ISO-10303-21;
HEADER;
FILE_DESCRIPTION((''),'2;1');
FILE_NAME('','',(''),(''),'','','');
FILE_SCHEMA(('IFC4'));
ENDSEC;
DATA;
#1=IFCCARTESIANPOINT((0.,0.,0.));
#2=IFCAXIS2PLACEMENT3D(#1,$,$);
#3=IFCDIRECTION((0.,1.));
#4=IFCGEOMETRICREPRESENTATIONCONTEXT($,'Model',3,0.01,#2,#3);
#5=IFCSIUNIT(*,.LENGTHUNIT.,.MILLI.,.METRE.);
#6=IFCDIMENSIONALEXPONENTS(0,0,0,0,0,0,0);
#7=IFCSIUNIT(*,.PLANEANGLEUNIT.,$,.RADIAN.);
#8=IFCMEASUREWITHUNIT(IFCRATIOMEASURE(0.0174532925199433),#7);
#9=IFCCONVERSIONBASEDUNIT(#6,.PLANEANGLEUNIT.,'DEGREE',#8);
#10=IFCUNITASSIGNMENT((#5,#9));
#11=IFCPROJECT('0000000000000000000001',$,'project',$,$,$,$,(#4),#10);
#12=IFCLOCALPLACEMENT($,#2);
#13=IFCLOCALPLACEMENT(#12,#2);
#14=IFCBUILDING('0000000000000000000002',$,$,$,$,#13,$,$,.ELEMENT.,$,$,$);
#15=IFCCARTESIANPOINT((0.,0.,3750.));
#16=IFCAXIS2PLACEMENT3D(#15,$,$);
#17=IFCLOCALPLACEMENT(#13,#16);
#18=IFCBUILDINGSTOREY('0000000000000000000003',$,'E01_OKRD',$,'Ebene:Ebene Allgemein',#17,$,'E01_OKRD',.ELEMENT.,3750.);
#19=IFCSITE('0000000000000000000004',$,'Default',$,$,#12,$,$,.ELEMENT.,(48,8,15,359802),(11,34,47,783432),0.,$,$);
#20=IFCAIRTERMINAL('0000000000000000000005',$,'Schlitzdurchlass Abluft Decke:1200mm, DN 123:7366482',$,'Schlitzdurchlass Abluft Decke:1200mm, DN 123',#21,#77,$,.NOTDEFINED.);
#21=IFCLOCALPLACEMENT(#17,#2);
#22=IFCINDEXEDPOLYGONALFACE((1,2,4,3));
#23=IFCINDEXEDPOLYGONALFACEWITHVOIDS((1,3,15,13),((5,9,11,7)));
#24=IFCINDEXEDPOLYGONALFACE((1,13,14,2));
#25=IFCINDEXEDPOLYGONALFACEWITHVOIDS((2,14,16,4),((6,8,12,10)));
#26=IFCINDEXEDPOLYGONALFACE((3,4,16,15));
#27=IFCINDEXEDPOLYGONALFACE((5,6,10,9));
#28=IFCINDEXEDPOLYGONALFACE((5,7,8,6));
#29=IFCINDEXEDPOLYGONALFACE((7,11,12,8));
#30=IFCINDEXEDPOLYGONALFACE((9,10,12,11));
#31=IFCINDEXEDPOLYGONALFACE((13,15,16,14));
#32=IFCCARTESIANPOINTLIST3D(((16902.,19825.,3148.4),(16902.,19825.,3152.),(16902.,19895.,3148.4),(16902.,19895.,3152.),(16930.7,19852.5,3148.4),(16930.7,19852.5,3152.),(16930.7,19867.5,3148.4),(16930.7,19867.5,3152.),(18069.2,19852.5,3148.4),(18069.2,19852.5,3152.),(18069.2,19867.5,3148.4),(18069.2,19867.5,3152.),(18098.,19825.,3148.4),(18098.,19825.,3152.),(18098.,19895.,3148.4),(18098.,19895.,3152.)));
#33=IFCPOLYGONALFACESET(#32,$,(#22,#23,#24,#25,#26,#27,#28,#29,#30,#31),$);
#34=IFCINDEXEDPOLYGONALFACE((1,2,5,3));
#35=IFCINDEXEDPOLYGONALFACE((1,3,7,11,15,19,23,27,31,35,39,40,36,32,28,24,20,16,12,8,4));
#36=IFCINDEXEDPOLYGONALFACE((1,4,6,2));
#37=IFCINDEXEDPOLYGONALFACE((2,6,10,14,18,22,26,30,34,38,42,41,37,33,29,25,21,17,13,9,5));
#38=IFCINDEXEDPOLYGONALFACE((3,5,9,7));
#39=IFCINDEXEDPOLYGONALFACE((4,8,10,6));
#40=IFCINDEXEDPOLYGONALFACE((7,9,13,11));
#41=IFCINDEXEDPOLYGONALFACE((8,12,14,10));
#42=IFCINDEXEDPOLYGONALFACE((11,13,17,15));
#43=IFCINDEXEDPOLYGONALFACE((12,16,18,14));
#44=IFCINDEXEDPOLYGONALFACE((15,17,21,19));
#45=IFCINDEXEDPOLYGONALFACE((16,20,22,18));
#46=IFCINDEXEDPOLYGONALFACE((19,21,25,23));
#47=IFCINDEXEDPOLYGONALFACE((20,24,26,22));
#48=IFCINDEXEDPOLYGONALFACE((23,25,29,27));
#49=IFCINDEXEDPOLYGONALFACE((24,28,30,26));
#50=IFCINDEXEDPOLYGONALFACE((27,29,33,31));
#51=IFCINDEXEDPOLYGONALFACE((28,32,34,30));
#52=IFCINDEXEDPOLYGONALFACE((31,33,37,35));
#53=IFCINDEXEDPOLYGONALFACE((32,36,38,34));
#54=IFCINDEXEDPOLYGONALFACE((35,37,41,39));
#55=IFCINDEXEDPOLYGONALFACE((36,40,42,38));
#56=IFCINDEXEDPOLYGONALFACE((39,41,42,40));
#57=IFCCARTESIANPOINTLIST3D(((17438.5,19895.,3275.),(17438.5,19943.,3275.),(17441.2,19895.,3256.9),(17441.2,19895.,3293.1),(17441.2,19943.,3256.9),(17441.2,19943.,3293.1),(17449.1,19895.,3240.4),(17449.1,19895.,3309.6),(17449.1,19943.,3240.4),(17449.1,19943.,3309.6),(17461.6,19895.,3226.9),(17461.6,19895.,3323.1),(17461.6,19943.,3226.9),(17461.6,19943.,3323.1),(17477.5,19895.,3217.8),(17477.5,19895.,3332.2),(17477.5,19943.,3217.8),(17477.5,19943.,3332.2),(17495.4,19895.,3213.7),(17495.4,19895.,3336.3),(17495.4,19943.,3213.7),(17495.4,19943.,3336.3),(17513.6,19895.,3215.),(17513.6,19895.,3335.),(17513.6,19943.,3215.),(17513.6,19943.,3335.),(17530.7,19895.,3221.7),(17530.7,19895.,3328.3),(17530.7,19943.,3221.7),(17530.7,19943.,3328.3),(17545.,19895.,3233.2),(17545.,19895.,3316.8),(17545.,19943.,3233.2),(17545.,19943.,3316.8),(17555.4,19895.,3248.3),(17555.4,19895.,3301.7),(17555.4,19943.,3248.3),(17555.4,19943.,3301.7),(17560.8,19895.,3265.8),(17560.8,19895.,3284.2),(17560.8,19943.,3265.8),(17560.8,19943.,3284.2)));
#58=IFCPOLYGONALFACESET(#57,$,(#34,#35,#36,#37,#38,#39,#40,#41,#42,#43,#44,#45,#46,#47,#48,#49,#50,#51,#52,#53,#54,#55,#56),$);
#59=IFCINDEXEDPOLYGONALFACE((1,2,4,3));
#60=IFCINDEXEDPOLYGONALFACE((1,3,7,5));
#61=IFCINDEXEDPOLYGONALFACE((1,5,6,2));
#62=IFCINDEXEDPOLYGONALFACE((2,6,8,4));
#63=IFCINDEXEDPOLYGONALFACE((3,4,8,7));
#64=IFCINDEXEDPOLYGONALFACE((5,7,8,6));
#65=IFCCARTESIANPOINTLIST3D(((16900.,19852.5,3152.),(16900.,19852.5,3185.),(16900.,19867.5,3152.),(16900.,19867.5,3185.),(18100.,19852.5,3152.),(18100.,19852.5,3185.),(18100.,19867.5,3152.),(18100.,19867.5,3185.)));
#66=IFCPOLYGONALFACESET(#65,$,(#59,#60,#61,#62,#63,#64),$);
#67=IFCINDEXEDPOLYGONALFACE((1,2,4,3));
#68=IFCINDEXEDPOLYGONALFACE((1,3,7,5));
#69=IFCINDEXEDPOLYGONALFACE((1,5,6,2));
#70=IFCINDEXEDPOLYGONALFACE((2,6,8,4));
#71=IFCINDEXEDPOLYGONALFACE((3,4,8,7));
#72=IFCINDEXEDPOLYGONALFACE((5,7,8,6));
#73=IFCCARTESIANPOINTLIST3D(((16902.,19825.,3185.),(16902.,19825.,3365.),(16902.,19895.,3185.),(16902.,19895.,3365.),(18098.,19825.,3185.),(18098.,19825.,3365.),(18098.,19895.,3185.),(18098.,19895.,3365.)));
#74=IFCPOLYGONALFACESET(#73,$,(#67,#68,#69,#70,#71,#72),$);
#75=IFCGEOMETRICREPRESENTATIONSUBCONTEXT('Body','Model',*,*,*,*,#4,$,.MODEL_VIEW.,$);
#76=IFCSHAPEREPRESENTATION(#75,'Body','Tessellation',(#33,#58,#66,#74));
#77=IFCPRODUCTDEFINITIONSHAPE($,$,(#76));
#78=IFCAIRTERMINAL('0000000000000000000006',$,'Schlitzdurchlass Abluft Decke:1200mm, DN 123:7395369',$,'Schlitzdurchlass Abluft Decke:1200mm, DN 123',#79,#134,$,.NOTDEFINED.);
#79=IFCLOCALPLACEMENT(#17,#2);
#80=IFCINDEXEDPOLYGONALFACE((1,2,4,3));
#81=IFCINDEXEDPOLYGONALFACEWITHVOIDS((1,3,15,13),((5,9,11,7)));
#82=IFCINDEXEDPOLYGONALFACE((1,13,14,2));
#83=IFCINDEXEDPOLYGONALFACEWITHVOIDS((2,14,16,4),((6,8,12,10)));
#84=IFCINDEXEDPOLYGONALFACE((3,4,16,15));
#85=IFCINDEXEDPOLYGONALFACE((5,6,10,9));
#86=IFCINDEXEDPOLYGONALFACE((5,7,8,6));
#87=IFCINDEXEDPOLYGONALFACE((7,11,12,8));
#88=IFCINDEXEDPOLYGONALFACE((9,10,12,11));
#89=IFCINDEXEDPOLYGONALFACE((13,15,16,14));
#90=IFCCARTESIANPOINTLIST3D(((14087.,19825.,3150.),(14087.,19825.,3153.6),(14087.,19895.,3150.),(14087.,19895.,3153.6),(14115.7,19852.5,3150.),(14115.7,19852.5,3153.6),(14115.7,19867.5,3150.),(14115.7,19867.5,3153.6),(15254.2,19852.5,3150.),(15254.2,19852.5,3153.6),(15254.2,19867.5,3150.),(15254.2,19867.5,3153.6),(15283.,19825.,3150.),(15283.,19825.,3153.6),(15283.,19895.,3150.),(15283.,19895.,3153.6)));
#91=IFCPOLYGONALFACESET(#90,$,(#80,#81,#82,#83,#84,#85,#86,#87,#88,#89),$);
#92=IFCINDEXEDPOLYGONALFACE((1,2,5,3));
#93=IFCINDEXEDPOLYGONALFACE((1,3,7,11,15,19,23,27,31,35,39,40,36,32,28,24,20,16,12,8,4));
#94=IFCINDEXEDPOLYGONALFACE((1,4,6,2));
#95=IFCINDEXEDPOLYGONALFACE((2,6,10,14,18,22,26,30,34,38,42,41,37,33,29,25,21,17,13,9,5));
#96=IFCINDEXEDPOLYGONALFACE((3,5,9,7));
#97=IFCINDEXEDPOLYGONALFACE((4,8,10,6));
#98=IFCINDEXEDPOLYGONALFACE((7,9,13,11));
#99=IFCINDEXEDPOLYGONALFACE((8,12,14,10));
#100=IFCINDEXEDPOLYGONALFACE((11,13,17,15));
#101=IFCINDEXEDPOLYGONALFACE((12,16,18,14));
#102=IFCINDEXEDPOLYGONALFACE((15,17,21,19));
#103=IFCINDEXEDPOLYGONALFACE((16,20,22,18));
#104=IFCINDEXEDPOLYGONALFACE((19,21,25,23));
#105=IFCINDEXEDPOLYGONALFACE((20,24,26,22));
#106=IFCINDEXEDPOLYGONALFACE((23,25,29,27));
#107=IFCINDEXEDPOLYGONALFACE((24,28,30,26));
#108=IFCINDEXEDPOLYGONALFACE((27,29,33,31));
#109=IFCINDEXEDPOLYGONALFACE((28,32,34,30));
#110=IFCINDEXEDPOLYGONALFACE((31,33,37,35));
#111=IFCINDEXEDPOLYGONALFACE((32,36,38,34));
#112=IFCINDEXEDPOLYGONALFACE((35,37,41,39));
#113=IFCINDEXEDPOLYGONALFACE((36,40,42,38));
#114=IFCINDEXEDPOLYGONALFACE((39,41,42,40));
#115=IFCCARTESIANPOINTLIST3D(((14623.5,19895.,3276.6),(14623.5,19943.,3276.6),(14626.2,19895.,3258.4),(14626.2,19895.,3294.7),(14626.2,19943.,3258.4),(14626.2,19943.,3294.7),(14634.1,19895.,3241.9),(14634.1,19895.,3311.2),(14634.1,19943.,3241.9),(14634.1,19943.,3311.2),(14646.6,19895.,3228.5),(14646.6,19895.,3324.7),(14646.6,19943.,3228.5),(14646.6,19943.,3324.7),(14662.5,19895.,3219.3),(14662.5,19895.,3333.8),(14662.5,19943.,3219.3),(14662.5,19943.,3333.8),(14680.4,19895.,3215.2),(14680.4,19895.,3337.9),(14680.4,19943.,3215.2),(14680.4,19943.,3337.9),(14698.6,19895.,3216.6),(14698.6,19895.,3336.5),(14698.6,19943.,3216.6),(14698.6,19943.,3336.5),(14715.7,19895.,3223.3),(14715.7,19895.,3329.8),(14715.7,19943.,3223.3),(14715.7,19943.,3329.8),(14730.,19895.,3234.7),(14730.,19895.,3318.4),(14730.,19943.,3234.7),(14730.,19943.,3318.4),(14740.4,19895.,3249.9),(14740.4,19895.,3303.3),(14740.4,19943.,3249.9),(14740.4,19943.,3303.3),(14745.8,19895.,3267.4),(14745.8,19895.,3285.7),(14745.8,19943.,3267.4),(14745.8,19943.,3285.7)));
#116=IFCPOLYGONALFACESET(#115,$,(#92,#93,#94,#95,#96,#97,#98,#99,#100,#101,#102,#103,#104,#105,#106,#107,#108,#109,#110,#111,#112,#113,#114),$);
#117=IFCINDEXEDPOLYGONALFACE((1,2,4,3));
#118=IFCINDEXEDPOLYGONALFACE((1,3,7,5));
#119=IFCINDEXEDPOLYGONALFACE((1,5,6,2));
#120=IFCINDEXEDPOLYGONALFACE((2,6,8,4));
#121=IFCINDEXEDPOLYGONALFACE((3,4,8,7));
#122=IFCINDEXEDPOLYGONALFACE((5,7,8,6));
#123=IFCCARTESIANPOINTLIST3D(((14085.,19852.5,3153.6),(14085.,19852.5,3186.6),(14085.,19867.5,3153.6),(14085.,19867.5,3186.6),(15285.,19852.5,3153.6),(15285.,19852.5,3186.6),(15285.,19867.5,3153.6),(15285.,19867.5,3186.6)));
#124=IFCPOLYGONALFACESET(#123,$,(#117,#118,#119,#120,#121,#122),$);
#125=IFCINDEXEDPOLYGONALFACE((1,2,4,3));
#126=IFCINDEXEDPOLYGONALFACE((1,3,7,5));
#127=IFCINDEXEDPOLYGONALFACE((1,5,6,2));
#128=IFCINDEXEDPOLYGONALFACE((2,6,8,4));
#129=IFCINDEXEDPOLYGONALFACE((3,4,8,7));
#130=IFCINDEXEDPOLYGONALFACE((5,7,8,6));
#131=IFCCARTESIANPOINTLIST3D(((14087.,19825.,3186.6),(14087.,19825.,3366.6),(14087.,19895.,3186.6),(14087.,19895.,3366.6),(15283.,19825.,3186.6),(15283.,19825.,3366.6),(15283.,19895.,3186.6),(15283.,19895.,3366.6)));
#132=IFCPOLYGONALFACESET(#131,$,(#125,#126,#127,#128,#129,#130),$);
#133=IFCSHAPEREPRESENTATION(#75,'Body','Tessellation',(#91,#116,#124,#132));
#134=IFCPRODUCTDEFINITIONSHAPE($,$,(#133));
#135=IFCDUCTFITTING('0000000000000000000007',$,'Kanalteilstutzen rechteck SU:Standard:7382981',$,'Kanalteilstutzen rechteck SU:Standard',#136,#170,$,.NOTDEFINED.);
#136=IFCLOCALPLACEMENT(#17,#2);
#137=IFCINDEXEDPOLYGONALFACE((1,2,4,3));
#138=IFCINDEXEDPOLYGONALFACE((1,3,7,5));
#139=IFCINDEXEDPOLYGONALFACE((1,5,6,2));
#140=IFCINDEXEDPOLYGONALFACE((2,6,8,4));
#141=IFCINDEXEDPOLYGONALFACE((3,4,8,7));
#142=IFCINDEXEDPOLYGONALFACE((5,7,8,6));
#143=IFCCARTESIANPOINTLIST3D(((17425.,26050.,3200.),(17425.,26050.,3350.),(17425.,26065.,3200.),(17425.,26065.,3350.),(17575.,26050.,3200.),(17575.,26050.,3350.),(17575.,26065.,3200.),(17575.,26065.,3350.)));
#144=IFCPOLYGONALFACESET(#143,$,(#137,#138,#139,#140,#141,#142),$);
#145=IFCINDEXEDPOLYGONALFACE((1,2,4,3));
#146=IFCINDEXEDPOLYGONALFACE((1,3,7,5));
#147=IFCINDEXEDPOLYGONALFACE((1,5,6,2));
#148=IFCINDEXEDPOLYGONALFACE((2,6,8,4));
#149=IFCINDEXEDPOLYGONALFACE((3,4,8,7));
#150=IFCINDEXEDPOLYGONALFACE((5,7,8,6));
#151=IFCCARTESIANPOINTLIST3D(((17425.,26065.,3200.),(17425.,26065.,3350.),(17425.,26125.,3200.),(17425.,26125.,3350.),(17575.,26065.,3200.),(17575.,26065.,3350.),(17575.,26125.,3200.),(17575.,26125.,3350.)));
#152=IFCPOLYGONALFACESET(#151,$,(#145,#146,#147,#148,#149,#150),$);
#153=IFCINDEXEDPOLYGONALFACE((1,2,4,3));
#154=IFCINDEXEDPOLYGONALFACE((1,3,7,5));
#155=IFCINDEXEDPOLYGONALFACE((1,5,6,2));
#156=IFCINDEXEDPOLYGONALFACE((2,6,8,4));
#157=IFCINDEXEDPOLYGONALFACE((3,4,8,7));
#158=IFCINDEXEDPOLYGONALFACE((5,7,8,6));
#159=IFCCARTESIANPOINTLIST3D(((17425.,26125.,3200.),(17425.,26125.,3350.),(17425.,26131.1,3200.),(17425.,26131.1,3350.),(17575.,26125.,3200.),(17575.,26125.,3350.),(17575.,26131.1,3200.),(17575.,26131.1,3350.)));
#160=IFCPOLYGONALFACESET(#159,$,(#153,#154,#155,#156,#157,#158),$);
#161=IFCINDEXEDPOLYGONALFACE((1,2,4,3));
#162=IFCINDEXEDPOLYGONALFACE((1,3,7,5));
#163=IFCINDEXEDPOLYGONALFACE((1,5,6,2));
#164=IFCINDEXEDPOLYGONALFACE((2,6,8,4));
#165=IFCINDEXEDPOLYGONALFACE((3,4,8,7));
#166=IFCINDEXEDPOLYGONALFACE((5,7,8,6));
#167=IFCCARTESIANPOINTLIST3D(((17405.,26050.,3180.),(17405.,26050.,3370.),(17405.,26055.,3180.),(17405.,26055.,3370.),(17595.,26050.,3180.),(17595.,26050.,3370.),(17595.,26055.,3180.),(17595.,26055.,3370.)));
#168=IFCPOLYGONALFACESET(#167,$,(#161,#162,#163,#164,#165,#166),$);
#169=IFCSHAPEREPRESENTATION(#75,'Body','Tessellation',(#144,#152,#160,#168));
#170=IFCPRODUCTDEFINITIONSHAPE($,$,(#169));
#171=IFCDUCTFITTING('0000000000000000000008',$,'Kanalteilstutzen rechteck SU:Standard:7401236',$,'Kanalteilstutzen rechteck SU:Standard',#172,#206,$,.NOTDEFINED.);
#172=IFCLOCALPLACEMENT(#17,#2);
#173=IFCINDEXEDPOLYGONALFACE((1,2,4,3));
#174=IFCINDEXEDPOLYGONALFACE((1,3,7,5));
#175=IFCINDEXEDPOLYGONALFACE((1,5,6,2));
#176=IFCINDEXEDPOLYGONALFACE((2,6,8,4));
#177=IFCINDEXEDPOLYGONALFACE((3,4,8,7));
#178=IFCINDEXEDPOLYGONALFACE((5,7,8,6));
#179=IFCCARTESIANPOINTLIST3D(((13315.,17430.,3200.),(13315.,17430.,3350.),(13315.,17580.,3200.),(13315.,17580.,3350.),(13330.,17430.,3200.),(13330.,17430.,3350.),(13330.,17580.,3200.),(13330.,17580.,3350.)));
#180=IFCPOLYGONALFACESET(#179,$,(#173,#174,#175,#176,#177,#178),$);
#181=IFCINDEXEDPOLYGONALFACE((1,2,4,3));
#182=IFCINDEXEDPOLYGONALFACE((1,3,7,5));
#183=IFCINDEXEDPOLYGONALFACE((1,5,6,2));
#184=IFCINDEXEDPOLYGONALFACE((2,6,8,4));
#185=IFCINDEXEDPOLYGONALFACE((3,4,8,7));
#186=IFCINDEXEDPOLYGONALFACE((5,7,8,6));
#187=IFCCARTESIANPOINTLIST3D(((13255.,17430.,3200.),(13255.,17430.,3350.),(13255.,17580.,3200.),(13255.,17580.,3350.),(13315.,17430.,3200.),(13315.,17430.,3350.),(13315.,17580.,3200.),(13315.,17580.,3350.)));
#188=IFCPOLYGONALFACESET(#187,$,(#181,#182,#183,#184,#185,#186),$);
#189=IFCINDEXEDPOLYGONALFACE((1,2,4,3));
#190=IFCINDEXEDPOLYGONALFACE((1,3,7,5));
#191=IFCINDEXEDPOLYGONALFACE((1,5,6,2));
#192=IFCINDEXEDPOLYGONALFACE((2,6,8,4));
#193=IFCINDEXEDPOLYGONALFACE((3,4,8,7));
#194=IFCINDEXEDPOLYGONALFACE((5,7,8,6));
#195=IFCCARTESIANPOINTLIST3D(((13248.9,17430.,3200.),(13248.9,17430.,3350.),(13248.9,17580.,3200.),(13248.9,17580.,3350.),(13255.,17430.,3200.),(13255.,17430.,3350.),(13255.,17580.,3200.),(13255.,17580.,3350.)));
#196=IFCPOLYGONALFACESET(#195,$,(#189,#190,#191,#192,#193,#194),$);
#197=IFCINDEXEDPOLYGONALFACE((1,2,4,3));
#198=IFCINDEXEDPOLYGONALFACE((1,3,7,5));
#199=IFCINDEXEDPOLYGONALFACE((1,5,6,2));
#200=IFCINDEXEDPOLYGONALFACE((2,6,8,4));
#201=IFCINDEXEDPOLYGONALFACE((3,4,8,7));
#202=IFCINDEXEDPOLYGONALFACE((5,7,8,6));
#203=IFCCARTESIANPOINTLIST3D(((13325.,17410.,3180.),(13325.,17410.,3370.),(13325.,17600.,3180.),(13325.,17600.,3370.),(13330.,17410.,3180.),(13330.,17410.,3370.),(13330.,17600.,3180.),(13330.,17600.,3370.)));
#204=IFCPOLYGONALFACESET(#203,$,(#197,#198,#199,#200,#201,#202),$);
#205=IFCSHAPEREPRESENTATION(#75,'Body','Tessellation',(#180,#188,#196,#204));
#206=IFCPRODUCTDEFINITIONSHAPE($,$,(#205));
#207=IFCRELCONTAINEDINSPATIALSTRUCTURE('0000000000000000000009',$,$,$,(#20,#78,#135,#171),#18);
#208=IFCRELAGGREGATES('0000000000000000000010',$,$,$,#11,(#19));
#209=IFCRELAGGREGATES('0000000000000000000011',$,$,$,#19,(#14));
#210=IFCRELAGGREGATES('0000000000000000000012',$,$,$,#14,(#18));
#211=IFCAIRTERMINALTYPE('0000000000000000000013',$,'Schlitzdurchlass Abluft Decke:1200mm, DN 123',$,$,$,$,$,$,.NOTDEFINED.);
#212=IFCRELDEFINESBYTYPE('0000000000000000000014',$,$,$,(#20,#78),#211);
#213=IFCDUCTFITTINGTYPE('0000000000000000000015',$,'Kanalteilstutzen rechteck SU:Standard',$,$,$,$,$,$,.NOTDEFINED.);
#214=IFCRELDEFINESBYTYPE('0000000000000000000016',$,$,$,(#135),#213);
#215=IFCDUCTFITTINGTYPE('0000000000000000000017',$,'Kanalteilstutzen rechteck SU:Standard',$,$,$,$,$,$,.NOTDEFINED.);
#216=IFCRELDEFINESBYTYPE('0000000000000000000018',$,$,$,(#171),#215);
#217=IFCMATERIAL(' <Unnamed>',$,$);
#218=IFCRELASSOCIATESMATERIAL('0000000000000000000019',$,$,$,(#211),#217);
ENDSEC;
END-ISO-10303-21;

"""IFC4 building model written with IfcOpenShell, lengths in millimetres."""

from ifc_helpers import new_model, entity, si_unit, converted_unit, direction, frame, frame_2d, origin, origin_2d_with_axis, place, context, subcontext, project, spatial, polyline, rectangle, circle, outline, extrude, source, transform, mapped, material, type_object, type_shapes, element, save


model = new_model("IFC4")

# Units and contexts
model_context = context("Model", 3, precision=0.01, world=origin(), true_north=direction((0.0, 1.0)))
body_context = subcontext(model_context, "Body", "Model", "MODEL_VIEW")
ifc_project = project(units=[si_unit("LENGTHUNIT", "METRE", prefix="MILLI"), converted_unit("PLANEANGLEUNIT", "DEGREE", entity("IfcRatioMeasure", 0.0174532925199433), si_unit("PLANEANGLEUNIT", "RADIAN"), dimensions=[0, 0, 0, 0, 0, 0, 0])], contexts=[model_context])

# Site, building, storey
site_placement = place(None, origin())
site = spatial("IfcSite", under=ifc_project, at=site_placement, Name="Default", CompositionType="ELEMENT", RefLatitude=(48, 8, 15, 359802), RefLongitude=(11, 34, 47, 783432), RefElevation=0.0)
building_placement = place(site_placement, origin())
building = spatial("IfcBuilding", under=site, at=building_placement, CompositionType="ELEMENT")
storey_placement = place(building_placement, frame((0.0, 0.0, 3750.0)))
storey = spatial("IfcBuildingStorey", under=building, at=storey_placement, Name="E01_OKRD", ObjectType="Ebene:Ebene Allgemein", LongName="E01_OKRD", CompositionType="ELEMENT", Elevation=3750.0)

# Air terminals
ifc_material_1 = material(Name=" <Unnamed>")
air_terminal_type_1 = type_object("IfcAirTerminalType", Name="Schlitzdurchlass Abluft Decke:1200mm, DN 123", PredefinedType="NOTDEFINED", material=ifc_material_1)
shared_shape_1 = source(origin(), body_context, "Body", "SweptSolid", [
    extrude(outline(polyline([(-598.0, -35.0), (598.0, -35.0), (598.0, 35.0), (-598.0, 35.0), (-598.0, -35.0)]), holes=[polyline([(-569.2, -7.5), (-569.2, 7.5), (569.2, 7.5), (569.2, -7.5), (-569.2, -7.5)])]), frame((0.0, 0.0, 0.0), z_axis=(0.0, 0.0, 1.0), x_axis=(-1.0, 0.0, 0.0)), (0.0, 0.0, 1.0), 3.6),
    extrude(circle(Radius=61.5, at=frame_2d((0.0, 0.0), x_axis=(1.0, 0.0))), frame((0.0, 35.0, 126.6), z_axis=(0.0, 1.0, 0.0), x_axis=(-1.0, 0.0, 0.0)), (0.0, 0.0, 1.0), 48.0),
    extrude(rectangle(XDim=1200.0, YDim=15.0, at=origin_2d_with_axis()), frame((0.0, 0.0, 3.6), z_axis=(0.0, 0.0, 1.0), x_axis=(-1.0, 0.0, 0.0)), (0.0, 0.0, 1.0), 33.0),
    extrude(rectangle(XDim=1196.0, YDim=70.0, at=origin_2d_with_axis()), frame((0.0, 0.0, 36.6), z_axis=(0.0, 0.0, 1.0), x_axis=(-1.0, 0.0, 0.0)), (0.0, 0.0, 1.0), 180.0),
])
type_shapes(air_terminal_type_1, [shared_shape_1])
for number, where, name in (
    (1, (17500.0, 19860.0, 3148.4), "Schlitzdurchlass Abluft Decke:1200mm, DN 123:7366482"),
    (2, (14685.0, 19860.0, 3150.0), "Schlitzdurchlass Abluft Decke:1200mm, DN 123:7395369"),
):
    element("IfcAirTerminal", number, at=place(storey_placement, frame(where)), inside=storey, type_object=air_terminal_type_1, Name=name, ObjectType="Schlitzdurchlass Abluft Decke:1200mm, DN 123", PredefinedType="NOTDEFINED", context=body_context, shape_type="MappedRepresentation", body=[
        mapped(shared_shape_1, transform((0.0, 0.0, 0.0), scale=1.0)),
    ])

# Duct fittings
duct_fitting_type_1 = type_object("IfcDuctFittingType", Name="Kanalteilstutzen rechteck SU:Standard", PredefinedType="NOTDEFINED")
shared_shape_2 = source(origin(), body_context, "Body", "SweptSolid", [
    extrude(rectangle(XDim=150.0, YDim=15.0, at=origin_2d_with_axis()), frame((67.5, 0.0, -75.0), z_axis=(0.0, 0.0, 1.0), x_axis=(0.0, -1.0, 0.0)), (0.0, 0.0, 1.0), 150.0),
    extrude(rectangle(XDim=150.0, YDim=60.0, at=frame_2d((0.0, 0.0), x_axis=(1.0, 0.0))), frame((30.0, 0.0, -75.0), z_axis=(0.0, 0.0, 1.0), x_axis=(0.0, -1.0, 0.0)), (0.0, 0.0, 1.0), 150.0),
    extrude(rectangle(XDim=150.0, YDim=6.1, at=frame_2d((0.0, 0.0), x_axis=(1.0, 0.0))), frame((-3.0, 0.0, -75.0), z_axis=(0.0, 0.0, 1.0), x_axis=(0.0, -1.0, 0.0)), (0.0, 0.0, 1.0), 150.0),
    extrude(rectangle(XDim=190.0, YDim=5.0, at=origin_2d_with_axis()), frame((72.5, 0.0, -95.0), z_axis=(0.0, 0.0, 1.0), x_axis=(0.0, -1.0, 0.0)), (0.0, 0.0, 1.0), 190.0),
])
type_shapes(duct_fitting_type_1, [shared_shape_2])
duct_fitting_1_placement = place(storey_placement, frame((17500.0, 26125.0, 3275.0), z_axis=(0.0, 0.0, -1.0), x_axis=(0.0, -1.0, 0.0)))
element("IfcDuctFitting", 3, at=duct_fitting_1_placement, inside=storey, type_object=duct_fitting_type_1, Name="Kanalteilstutzen rechteck SU:Standard:7382981", ObjectType="Kanalteilstutzen rechteck SU:Standard", PredefinedType="NOTDEFINED", context=body_context, shape_type="MappedRepresentation", body=[
    mapped(shared_shape_2, transform((0.0, 0.0, 0.0), scale=1.0)),
])
duct_fitting_type_2 = type_object("IfcDuctFittingType", Name="Kanalteilstutzen rechteck SU:Standard", PredefinedType="NOTDEFINED")
shared_shape_3 = source(origin(), body_context, "Body", "SweptSolid", [
    extrude(rectangle(XDim=15.0, YDim=150.0, at=frame_2d((0.0, 0.0), x_axis=(1.0, 0.0))), frame((67.5, 0.0, -75.0)), (0.0, 0.0, 1.0), 150.0),
    extrude(rectangle(XDim=60.0, YDim=150.0, at=frame_2d((0.0, 0.0), x_axis=(1.0, 0.0))), frame((30.0, 0.0, -75.0)), (0.0, 0.0, 1.0), 150.0),
    extrude(rectangle(XDim=6.1, YDim=150.0, at=frame_2d((0.0, 0.0), x_axis=(1.0, 0.0))), frame((-3.0, 0.0, -75.0)), (0.0, 0.0, 1.0), 150.0),
    extrude(rectangle(XDim=5.0, YDim=190.0, at=origin_2d_with_axis()), frame((72.5, 0.0, -95.0)), (0.0, 0.0, 1.0), 190.0),
])
type_shapes(duct_fitting_type_2, [shared_shape_3])
for number, where, z_axis, x_axis, name in (
    (4, (13255.0, 17505.0, 3275.0), (0.0, 0.0, -1.0), (1.0, 0.0, 0.0), "Kanalteilstutzen rechteck SU:Standard:7401236"),
):
    element("IfcDuctFitting", number, at=place(storey_placement, frame(where, z_axis=z_axis, x_axis=x_axis)), inside=storey, type_object=duct_fitting_type_2, Name=name, ObjectType="Kanalteilstutzen rechteck SU:Standard", PredefinedType="NOTDEFINED", context=body_context, shape_type="MappedRepresentation", body=[
        mapped(shared_shape_3, transform((0.0, 0.0, 0.0), scale=1.0)),
    ])

save(model, "model.ifc")
